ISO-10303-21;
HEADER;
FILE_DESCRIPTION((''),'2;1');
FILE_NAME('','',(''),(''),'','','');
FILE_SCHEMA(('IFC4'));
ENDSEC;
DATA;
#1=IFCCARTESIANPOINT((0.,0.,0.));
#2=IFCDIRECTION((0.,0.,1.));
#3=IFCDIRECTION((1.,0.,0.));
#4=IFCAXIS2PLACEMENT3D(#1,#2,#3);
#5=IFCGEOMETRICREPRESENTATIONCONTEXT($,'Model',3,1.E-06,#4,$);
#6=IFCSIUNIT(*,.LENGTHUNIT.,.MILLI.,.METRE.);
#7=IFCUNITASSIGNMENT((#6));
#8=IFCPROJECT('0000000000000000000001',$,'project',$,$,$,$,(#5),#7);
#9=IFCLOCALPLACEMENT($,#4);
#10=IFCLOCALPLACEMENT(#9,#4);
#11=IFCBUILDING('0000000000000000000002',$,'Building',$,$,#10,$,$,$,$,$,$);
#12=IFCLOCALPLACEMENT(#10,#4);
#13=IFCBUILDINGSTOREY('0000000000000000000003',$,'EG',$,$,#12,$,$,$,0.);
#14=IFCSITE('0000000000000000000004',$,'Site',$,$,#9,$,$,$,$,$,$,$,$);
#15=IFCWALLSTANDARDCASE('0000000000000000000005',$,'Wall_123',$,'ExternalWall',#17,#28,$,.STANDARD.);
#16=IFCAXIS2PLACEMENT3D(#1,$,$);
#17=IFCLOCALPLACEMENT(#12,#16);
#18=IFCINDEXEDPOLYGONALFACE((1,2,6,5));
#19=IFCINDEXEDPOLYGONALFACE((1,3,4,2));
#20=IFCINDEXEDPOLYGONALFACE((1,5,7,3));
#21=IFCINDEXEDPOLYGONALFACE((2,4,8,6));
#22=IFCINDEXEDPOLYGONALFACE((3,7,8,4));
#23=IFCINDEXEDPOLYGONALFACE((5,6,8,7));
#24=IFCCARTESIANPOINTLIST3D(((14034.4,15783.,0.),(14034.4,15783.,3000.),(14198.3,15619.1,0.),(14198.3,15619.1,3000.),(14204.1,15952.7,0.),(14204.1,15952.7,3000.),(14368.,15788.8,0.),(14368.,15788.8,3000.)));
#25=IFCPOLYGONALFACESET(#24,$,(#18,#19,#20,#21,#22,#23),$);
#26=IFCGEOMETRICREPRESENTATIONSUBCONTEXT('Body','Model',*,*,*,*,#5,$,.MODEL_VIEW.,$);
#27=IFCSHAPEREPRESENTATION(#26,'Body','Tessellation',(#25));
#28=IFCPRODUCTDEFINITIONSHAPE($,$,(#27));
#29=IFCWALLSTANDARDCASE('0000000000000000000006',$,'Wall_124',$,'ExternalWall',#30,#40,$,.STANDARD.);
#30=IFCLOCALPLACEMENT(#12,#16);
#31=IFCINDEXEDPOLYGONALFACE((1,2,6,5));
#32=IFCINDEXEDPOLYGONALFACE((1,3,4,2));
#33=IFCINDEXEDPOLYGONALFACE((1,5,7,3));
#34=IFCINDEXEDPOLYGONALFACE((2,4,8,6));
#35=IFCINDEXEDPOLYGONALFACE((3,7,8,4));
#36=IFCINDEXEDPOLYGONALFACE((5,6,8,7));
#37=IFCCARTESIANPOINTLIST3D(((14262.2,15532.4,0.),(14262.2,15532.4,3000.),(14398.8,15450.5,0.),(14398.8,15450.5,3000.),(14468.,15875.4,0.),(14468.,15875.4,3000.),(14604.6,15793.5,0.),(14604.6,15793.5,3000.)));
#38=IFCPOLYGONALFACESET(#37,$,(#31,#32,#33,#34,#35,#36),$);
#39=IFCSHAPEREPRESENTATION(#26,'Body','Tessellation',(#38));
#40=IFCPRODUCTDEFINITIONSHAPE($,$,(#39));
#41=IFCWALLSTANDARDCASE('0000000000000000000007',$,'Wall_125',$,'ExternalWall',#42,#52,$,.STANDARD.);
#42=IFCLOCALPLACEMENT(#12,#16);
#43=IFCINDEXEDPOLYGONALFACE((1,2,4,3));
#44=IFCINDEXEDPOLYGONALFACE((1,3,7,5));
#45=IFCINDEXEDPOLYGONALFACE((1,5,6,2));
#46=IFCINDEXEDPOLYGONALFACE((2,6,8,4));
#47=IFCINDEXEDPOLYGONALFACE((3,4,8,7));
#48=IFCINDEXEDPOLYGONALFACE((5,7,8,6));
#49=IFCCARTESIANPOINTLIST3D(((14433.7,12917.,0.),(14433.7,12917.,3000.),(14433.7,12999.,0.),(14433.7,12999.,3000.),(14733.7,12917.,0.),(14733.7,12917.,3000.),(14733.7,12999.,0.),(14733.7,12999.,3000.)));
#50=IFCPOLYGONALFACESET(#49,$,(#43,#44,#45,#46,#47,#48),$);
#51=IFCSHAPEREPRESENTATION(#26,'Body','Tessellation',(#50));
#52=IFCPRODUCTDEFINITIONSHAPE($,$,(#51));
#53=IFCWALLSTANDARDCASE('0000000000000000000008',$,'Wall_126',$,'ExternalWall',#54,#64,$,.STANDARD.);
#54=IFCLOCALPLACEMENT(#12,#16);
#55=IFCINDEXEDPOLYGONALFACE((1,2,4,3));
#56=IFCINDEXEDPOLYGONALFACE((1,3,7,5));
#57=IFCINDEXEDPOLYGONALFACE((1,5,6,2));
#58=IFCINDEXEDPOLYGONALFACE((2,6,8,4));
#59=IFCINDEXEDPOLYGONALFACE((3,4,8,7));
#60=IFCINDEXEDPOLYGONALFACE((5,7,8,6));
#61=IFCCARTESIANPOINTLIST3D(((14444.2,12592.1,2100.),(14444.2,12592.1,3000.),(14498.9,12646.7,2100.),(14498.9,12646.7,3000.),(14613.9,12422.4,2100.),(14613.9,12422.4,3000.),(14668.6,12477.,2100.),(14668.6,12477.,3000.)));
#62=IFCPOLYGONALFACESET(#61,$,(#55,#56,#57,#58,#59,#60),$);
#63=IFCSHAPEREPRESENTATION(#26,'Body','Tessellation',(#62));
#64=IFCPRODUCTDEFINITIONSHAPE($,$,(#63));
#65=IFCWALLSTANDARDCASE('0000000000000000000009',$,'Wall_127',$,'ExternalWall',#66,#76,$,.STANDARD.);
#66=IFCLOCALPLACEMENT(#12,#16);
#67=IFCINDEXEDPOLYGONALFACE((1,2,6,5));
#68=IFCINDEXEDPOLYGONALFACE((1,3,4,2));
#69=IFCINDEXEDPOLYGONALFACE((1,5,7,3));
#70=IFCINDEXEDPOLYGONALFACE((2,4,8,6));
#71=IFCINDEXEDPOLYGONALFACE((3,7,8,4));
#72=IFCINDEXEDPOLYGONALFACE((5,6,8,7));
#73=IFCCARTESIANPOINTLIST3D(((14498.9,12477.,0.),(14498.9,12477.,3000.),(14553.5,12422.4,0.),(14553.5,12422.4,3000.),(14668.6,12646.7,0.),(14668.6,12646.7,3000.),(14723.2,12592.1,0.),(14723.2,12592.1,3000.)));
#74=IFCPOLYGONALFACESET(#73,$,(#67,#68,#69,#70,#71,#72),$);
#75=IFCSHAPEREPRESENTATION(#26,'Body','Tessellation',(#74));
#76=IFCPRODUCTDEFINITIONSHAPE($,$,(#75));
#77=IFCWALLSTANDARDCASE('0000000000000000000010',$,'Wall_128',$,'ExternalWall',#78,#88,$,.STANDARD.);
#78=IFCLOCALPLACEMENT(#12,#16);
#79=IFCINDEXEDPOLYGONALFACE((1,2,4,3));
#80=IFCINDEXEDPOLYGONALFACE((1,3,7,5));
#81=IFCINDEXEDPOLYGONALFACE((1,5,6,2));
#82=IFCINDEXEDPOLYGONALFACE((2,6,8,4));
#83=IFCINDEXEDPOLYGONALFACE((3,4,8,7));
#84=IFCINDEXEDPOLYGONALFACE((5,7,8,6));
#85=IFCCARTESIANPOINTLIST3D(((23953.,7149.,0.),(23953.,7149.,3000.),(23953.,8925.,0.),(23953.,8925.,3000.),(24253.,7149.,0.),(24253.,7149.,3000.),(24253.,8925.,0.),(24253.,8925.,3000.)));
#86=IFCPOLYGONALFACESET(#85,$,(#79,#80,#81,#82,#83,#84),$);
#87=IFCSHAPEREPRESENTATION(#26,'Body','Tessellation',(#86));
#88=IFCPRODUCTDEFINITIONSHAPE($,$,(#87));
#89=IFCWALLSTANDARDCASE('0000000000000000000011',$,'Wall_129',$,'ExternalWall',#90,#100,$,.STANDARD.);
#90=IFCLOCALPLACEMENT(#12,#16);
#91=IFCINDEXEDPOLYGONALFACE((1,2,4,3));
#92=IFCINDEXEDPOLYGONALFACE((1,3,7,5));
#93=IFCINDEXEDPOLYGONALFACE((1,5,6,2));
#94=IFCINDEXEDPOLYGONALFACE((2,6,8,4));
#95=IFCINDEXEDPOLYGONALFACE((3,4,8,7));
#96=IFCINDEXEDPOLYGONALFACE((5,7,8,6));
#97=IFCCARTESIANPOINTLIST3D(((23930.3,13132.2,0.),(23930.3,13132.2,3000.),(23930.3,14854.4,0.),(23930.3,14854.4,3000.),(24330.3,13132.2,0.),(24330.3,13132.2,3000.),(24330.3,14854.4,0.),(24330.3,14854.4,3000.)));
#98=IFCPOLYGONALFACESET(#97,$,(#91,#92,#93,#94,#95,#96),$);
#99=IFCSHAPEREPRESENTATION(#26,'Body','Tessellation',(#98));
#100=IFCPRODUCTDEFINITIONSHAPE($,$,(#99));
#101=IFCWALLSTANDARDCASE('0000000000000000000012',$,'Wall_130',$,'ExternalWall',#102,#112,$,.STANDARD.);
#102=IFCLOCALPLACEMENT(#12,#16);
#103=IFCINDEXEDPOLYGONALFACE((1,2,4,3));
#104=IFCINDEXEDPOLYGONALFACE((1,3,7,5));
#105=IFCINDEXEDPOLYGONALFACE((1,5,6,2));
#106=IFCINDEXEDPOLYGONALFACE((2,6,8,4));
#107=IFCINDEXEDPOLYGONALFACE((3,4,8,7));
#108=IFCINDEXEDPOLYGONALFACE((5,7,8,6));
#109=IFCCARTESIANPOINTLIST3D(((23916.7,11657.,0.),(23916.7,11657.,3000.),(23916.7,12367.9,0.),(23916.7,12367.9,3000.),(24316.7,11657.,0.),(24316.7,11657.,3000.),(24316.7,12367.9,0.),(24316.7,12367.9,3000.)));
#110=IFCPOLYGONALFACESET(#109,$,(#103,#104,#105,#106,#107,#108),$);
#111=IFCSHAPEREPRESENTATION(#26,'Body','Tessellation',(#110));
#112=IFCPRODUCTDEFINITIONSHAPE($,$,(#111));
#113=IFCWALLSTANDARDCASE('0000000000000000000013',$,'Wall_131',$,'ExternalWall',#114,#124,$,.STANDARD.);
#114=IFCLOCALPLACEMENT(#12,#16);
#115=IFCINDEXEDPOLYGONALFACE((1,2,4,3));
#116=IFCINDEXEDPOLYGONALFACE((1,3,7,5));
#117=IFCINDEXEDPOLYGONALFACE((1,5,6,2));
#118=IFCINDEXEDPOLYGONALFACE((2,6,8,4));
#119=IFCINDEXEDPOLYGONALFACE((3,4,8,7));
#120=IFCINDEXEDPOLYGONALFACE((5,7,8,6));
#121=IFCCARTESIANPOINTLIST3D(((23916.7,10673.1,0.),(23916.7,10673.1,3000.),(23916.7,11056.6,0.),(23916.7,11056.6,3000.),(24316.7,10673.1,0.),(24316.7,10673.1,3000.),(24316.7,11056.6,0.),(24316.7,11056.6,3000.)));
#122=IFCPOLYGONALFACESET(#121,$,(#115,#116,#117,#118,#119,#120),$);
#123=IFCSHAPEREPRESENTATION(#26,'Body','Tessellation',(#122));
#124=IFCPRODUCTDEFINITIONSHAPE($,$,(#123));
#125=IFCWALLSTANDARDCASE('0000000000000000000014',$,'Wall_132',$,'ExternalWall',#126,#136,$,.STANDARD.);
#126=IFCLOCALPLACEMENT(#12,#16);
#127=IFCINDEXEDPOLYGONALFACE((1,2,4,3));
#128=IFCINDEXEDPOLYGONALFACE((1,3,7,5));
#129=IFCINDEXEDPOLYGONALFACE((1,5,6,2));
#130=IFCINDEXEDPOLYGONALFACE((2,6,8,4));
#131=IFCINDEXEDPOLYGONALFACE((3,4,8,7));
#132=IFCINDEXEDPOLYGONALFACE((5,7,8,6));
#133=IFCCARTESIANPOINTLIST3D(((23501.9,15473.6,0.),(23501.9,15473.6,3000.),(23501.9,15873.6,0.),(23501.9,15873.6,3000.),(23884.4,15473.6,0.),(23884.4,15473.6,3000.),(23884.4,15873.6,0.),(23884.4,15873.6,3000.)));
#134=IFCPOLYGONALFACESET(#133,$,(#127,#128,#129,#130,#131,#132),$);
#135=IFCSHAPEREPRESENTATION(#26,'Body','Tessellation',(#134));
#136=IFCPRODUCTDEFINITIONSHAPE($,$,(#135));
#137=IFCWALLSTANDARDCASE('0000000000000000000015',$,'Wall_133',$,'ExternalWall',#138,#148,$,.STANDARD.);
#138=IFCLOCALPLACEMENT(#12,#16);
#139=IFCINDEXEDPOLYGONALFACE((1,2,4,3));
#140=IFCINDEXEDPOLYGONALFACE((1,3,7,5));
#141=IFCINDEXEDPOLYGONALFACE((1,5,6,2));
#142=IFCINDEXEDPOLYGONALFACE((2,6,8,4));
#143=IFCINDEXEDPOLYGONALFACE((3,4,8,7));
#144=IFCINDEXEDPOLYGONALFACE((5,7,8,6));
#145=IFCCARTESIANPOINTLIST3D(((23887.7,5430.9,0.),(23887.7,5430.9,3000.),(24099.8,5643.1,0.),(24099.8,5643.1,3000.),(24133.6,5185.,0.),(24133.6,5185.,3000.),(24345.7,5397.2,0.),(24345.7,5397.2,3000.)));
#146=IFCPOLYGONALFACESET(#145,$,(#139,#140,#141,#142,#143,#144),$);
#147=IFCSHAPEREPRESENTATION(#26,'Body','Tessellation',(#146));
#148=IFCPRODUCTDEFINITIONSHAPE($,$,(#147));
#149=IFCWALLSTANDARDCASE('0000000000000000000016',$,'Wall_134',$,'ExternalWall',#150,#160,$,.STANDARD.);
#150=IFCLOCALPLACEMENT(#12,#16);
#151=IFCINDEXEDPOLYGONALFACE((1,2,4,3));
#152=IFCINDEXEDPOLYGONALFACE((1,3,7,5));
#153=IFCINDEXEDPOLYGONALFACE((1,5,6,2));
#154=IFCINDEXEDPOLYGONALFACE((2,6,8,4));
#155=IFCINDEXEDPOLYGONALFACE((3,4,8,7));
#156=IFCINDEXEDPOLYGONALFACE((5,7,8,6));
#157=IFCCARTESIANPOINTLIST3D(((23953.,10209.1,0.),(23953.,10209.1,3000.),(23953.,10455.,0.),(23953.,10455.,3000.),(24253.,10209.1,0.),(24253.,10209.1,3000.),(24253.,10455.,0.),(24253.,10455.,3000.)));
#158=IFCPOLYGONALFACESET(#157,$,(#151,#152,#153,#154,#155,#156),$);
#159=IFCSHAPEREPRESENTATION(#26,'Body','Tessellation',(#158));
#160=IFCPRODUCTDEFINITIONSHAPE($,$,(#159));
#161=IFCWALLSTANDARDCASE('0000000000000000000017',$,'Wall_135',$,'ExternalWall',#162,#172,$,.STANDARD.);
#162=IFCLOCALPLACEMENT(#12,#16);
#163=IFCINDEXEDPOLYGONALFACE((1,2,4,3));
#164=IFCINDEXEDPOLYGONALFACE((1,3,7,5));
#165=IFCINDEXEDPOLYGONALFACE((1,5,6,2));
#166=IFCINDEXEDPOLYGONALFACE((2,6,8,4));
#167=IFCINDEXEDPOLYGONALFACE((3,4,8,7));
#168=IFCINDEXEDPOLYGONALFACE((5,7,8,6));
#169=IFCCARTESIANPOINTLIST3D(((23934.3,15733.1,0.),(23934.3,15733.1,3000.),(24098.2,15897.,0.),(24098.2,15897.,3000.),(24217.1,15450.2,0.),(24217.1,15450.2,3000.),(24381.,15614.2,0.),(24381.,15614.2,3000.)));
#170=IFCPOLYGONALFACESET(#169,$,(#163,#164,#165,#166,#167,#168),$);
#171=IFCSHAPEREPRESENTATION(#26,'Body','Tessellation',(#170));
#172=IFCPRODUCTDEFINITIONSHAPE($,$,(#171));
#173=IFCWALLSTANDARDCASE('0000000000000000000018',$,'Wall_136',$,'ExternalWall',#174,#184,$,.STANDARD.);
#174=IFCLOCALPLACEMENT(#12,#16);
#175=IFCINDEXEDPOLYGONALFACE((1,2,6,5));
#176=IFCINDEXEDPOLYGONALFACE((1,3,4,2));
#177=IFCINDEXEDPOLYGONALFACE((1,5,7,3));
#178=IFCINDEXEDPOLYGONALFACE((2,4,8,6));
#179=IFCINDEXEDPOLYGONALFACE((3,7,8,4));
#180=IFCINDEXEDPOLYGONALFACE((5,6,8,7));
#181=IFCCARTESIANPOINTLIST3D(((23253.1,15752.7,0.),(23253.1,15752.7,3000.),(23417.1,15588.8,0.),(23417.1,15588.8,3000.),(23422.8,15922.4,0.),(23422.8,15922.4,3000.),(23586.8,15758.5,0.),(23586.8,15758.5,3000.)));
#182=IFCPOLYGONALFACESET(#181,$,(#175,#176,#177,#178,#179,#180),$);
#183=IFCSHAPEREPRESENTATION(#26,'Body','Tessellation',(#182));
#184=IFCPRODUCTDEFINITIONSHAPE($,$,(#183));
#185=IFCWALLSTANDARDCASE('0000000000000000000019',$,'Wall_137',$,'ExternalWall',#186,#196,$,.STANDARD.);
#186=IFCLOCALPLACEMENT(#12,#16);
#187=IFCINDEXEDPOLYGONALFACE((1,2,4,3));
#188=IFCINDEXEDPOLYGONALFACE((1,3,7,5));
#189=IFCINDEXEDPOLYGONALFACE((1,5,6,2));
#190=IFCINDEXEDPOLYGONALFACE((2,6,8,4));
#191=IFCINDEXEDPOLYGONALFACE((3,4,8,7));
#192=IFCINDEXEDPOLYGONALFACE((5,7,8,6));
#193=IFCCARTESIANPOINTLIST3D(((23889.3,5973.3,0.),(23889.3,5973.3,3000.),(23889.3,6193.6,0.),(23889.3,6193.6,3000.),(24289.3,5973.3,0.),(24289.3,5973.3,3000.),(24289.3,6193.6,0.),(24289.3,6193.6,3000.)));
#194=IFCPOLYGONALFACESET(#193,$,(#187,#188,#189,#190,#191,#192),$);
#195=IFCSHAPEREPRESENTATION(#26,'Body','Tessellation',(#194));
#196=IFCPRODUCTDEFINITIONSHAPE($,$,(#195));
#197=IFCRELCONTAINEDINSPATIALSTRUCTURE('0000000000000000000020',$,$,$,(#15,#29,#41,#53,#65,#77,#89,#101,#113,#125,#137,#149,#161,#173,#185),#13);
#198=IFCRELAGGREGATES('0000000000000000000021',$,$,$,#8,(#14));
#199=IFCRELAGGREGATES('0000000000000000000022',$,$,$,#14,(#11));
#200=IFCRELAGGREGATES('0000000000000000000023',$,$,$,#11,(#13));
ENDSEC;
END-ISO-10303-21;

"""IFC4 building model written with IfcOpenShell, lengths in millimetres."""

from ifc_helpers import new_model, si_unit, frame, origin_with_axes, place, context, subcontext, project, spatial, rectangle, extrude, element, save


model = new_model("IFC4")

# Units and contexts
model_context = context("Model", 3, precision=1e-06, world=origin_with_axes())
body_context = subcontext(model_context, "Body", "Model", "MODEL_VIEW")
ifc_project = project(units=[si_unit("LENGTHUNIT", "METRE", prefix="MILLI")], contexts=[model_context])

# Site, building, storey
site_placement = place(None, origin_with_axes())
site = spatial("IfcSite", under=ifc_project, at=site_placement, Name="Site")
building_placement = place(site_placement, origin_with_axes())
building = spatial("IfcBuilding", under=site, at=building_placement, Name="Building")
storey_placement = place(building_placement, origin_with_axes())
storey = spatial("IfcBuildingStorey", under=building, at=storey_placement, Name="EG", Elevation=0.0)

# Walls
wall_1_placement = place(storey_placement, origin_with_axes())
element("IfcWallStandardCase", 1, at=wall_1_placement, inside=storey, Name="Wall_123", ObjectType="ExternalWall", PredefinedType="STANDARD", context=body_context, shape_type="SweptSolid", body=[
    extrude(rectangle(XDim=231.8, YDim=240.0), frame((14201.2, 15785.9, 0.0), z_axis=(0.0, 0.0, 1.0), x_axis=(-0.707107, 0.707107, 0.0)), (0.0, 0.0, 1.0), 3000.0),
])
wall_2_placement = place(storey_placement, origin_with_axes())
element("IfcWallStandardCase", 2, at=wall_2_placement, inside=storey, Name="Wall_124", ObjectType="ExternalWall", PredefinedType="STANDARD", context=body_context, shape_type="SweptSolid", body=[
    extrude(rectangle(XDim=159.3, YDim=400.0), frame((14433.4, 15662.9, 0.0), z_axis=(0.0, 0.0, 1.0), x_axis=(-0.857493, 0.514496, 0.0)), (0.0, 0.0, 1.0), 3000.0),
])
wall_3_placement = place(storey_placement, origin_with_axes())
element("IfcWallStandardCase", 3, at=wall_3_placement, inside=storey, Name="Wall_125", ObjectType="ExternalWall", PredefinedType="STANDARD", context=body_context, shape_type="SweptSolid", body=[
    extrude(rectangle(XDim=82.0, YDim=300.0), frame((14583.7, 12958.0, 0.0), z_axis=(0.0, 0.0, 1.0), x_axis=(0.0, -1.0, 0.0)), (0.0, 0.0, 1.0), 3000.0),
])

# Wall, opening
wall_4_placement = place(storey_placement, origin_with_axes())
wall_4 = element("IfcWallStandardCase", 4, at=wall_4_placement, inside=storey, Name="Wall_126", ObjectType="ExternalWall", PredefinedType="STANDARD", context=body_context, shape_type="SweptSolid", body=[
    extrude(rectangle(XDim=77.3, YDim=240.0), frame((14556.4, 12534.5, 0.0), z_axis=(0.0, 0.0, 1.0), x_axis=(-0.707107, -0.707107, 0.0)), (0.0, 0.0, 1.0), 3000.0),
])
opening_placement = place(wall_4_placement, origin_with_axes())
element("IfcOpeningElement", 5, at=opening_placement, inside=storey, cuts=wall_4, context=body_context, shape_type="SweptSolid", body=[
    extrude(rectangle(XDim=1086.4, YDim=240.0), frame((14207.5, 12185.7, 0.0), z_axis=(0.0, 0.0, 1.0), x_axis=(-0.707107, -0.707107, 0.0)), (0.0, 0.0, 1.0), 2100.0),
])

# Walls
wall_5_placement = place(storey_placement, origin_with_axes())
element("IfcWallStandardCase", 6, at=wall_5_placement, inside=storey, Name="Wall_127", ObjectType="ExternalWall", PredefinedType="STANDARD", context=body_context, shape_type="SweptSolid", body=[
    extrude(rectangle(XDim=77.3, YDim=240.0), frame((14611.0, 12534.5, 0.0), z_axis=(0.0, 0.0, 1.0), x_axis=(0.707107, -0.707107, 0.0)), (0.0, 0.0, 1.0), 3000.0),
])
wall_6_placement = place(storey_placement, origin_with_axes())
element("IfcWallStandardCase", 7, at=wall_6_placement, inside=storey, Name="Wall_128", ObjectType="ExternalWall", PredefinedType="STANDARD", context=body_context, shape_type="SweptSolid", body=[
    extrude(rectangle(XDim=1776.0, YDim=300.0), frame((24103.0, 8037.0, 0.0), z_axis=(0.0, 0.0, 1.0), x_axis=(0.0, -1.0, 0.0)), (0.0, 0.0, 1.0), 3000.0),
])
wall_7_placement = place(storey_placement, origin_with_axes())
element("IfcWallStandardCase", 8, at=wall_7_placement, inside=storey, Name="Wall_129", ObjectType="ExternalWall", PredefinedType="STANDARD", context=body_context, shape_type="SweptSolid", body=[
    extrude(rectangle(XDim=1722.2, YDim=400.0), frame((24130.3, 13993.3, 0.0), z_axis=(0.0, 0.0, 1.0), x_axis=(0.0, 1.0, 0.0)), (0.0, 0.0, 1.0), 3000.0),
])
wall_8_placement = place(storey_placement, origin_with_axes())
element("IfcWallStandardCase", 9, at=wall_8_placement, inside=storey, Name="Wall_130", ObjectType="ExternalWall", PredefinedType="STANDARD", context=body_context, shape_type="SweptSolid", body=[
    extrude(rectangle(XDim=710.9, YDim=400.0), frame((24116.7, 12012.4, 0.0), z_axis=(0.0, 0.0, 1.0), x_axis=(0.0, -1.0, 0.0)), (0.0, 0.0, 1.0), 3000.0),
])
wall_9_placement = place(storey_placement, origin_with_axes())
element("IfcWallStandardCase", 10, at=wall_9_placement, inside=storey, Name="Wall_131", ObjectType="ExternalWall", PredefinedType="STANDARD", context=body_context, shape_type="SweptSolid", body=[
    extrude(rectangle(XDim=383.5, YDim=400.0), frame((24116.7, 10864.9, 0.0), z_axis=(0.0, 0.0, 1.0), x_axis=(0.0, -1.0, 0.0)), (0.0, 0.0, 1.0), 3000.0),
])
wall_10_placement = place(storey_placement, origin_with_axes())
element("IfcWallStandardCase", 11, at=wall_10_placement, inside=storey, Name="Wall_132", ObjectType="ExternalWall", PredefinedType="STANDARD", context=body_context, shape_type="SweptSolid", body=[
    extrude(rectangle(XDim=382.5, YDim=400.0), frame((23693.2, 15673.6, 0.0), z_axis=(0.0, 0.0, 1.0), x_axis=(-1.0, 0.0, 0.0)), (0.0, 0.0, 1.0), 3000.0),
])
wall_11_placement = place(storey_placement, origin_with_axes())
element("IfcWallStandardCase", 12, at=wall_11_placement, inside=storey, Name="Wall_133", ObjectType="ExternalWall", PredefinedType="STANDARD", context=body_context, shape_type="SweptSolid", body=[
    extrude(rectangle(XDim=347.8, YDim=300.0), frame((24116.7, 5414.1, 0.0), z_axis=(0.0, 0.0, 1.0), x_axis=(0.707107, -0.707107, 0.0)), (0.0, 0.0, 1.0), 3000.0),
])
wall_12_placement = place(storey_placement, origin_with_axes())
element("IfcWallStandardCase", 13, at=wall_12_placement, inside=storey, Name="Wall_134", ObjectType="ExternalWall", PredefinedType="STANDARD", context=body_context, shape_type="SweptSolid", body=[
    extrude(rectangle(XDim=245.9, YDim=300.0), frame((24103.0, 10332.1, 0.0), z_axis=(0.0, 0.0, 1.0), x_axis=(0.0, -1.0, 0.0)), (0.0, 0.0, 1.0), 3000.0),
])
wall_13_placement = place(storey_placement, origin_with_axes())
element("IfcWallStandardCase", 14, at=wall_13_placement, inside=storey, Name="Wall_135", ObjectType="ExternalWall", PredefinedType="STANDARD", context=body_context, shape_type="SweptSolid", body=[
    extrude(rectangle(XDim=231.8, YDim=400.0), frame((24157.7, 15673.6, 0.0), z_axis=(0.0, 0.0, 1.0), x_axis=(0.707107, 0.707107, 0.0)), (0.0, 0.0, 1.0), 3000.0),
])
wall_14_placement = place(storey_placement, origin_with_axes())
element("IfcWallStandardCase", 15, at=wall_14_placement, inside=storey, Name="Wall_136", ObjectType="ExternalWall", PredefinedType="STANDARD", context=body_context, shape_type="SweptSolid", body=[
    extrude(rectangle(XDim=231.8, YDim=240.0), frame((23419.9, 15755.6, 0.0), z_axis=(0.0, 0.0, 1.0), x_axis=(-0.707107, 0.707107, 0.0)), (0.0, 0.0, 1.0), 3000.0),
])
wall_15_placement = place(storey_placement, origin_with_axes())
element("IfcWallStandardCase", 16, at=wall_15_placement, inside=storey, Name="Wall_137", ObjectType="ExternalWall", PredefinedType="STANDARD", context=body_context, shape_type="SweptSolid", body=[
    extrude(rectangle(XDim=220.3, YDim=400.0), frame((24089.3, 6083.5, 0.0), z_axis=(0.0, 0.0, 1.0), x_axis=(0.0, -1.0, 0.0)), (0.0, 0.0, 1.0), 3000.0),
])

save(model, "model.ifc")
